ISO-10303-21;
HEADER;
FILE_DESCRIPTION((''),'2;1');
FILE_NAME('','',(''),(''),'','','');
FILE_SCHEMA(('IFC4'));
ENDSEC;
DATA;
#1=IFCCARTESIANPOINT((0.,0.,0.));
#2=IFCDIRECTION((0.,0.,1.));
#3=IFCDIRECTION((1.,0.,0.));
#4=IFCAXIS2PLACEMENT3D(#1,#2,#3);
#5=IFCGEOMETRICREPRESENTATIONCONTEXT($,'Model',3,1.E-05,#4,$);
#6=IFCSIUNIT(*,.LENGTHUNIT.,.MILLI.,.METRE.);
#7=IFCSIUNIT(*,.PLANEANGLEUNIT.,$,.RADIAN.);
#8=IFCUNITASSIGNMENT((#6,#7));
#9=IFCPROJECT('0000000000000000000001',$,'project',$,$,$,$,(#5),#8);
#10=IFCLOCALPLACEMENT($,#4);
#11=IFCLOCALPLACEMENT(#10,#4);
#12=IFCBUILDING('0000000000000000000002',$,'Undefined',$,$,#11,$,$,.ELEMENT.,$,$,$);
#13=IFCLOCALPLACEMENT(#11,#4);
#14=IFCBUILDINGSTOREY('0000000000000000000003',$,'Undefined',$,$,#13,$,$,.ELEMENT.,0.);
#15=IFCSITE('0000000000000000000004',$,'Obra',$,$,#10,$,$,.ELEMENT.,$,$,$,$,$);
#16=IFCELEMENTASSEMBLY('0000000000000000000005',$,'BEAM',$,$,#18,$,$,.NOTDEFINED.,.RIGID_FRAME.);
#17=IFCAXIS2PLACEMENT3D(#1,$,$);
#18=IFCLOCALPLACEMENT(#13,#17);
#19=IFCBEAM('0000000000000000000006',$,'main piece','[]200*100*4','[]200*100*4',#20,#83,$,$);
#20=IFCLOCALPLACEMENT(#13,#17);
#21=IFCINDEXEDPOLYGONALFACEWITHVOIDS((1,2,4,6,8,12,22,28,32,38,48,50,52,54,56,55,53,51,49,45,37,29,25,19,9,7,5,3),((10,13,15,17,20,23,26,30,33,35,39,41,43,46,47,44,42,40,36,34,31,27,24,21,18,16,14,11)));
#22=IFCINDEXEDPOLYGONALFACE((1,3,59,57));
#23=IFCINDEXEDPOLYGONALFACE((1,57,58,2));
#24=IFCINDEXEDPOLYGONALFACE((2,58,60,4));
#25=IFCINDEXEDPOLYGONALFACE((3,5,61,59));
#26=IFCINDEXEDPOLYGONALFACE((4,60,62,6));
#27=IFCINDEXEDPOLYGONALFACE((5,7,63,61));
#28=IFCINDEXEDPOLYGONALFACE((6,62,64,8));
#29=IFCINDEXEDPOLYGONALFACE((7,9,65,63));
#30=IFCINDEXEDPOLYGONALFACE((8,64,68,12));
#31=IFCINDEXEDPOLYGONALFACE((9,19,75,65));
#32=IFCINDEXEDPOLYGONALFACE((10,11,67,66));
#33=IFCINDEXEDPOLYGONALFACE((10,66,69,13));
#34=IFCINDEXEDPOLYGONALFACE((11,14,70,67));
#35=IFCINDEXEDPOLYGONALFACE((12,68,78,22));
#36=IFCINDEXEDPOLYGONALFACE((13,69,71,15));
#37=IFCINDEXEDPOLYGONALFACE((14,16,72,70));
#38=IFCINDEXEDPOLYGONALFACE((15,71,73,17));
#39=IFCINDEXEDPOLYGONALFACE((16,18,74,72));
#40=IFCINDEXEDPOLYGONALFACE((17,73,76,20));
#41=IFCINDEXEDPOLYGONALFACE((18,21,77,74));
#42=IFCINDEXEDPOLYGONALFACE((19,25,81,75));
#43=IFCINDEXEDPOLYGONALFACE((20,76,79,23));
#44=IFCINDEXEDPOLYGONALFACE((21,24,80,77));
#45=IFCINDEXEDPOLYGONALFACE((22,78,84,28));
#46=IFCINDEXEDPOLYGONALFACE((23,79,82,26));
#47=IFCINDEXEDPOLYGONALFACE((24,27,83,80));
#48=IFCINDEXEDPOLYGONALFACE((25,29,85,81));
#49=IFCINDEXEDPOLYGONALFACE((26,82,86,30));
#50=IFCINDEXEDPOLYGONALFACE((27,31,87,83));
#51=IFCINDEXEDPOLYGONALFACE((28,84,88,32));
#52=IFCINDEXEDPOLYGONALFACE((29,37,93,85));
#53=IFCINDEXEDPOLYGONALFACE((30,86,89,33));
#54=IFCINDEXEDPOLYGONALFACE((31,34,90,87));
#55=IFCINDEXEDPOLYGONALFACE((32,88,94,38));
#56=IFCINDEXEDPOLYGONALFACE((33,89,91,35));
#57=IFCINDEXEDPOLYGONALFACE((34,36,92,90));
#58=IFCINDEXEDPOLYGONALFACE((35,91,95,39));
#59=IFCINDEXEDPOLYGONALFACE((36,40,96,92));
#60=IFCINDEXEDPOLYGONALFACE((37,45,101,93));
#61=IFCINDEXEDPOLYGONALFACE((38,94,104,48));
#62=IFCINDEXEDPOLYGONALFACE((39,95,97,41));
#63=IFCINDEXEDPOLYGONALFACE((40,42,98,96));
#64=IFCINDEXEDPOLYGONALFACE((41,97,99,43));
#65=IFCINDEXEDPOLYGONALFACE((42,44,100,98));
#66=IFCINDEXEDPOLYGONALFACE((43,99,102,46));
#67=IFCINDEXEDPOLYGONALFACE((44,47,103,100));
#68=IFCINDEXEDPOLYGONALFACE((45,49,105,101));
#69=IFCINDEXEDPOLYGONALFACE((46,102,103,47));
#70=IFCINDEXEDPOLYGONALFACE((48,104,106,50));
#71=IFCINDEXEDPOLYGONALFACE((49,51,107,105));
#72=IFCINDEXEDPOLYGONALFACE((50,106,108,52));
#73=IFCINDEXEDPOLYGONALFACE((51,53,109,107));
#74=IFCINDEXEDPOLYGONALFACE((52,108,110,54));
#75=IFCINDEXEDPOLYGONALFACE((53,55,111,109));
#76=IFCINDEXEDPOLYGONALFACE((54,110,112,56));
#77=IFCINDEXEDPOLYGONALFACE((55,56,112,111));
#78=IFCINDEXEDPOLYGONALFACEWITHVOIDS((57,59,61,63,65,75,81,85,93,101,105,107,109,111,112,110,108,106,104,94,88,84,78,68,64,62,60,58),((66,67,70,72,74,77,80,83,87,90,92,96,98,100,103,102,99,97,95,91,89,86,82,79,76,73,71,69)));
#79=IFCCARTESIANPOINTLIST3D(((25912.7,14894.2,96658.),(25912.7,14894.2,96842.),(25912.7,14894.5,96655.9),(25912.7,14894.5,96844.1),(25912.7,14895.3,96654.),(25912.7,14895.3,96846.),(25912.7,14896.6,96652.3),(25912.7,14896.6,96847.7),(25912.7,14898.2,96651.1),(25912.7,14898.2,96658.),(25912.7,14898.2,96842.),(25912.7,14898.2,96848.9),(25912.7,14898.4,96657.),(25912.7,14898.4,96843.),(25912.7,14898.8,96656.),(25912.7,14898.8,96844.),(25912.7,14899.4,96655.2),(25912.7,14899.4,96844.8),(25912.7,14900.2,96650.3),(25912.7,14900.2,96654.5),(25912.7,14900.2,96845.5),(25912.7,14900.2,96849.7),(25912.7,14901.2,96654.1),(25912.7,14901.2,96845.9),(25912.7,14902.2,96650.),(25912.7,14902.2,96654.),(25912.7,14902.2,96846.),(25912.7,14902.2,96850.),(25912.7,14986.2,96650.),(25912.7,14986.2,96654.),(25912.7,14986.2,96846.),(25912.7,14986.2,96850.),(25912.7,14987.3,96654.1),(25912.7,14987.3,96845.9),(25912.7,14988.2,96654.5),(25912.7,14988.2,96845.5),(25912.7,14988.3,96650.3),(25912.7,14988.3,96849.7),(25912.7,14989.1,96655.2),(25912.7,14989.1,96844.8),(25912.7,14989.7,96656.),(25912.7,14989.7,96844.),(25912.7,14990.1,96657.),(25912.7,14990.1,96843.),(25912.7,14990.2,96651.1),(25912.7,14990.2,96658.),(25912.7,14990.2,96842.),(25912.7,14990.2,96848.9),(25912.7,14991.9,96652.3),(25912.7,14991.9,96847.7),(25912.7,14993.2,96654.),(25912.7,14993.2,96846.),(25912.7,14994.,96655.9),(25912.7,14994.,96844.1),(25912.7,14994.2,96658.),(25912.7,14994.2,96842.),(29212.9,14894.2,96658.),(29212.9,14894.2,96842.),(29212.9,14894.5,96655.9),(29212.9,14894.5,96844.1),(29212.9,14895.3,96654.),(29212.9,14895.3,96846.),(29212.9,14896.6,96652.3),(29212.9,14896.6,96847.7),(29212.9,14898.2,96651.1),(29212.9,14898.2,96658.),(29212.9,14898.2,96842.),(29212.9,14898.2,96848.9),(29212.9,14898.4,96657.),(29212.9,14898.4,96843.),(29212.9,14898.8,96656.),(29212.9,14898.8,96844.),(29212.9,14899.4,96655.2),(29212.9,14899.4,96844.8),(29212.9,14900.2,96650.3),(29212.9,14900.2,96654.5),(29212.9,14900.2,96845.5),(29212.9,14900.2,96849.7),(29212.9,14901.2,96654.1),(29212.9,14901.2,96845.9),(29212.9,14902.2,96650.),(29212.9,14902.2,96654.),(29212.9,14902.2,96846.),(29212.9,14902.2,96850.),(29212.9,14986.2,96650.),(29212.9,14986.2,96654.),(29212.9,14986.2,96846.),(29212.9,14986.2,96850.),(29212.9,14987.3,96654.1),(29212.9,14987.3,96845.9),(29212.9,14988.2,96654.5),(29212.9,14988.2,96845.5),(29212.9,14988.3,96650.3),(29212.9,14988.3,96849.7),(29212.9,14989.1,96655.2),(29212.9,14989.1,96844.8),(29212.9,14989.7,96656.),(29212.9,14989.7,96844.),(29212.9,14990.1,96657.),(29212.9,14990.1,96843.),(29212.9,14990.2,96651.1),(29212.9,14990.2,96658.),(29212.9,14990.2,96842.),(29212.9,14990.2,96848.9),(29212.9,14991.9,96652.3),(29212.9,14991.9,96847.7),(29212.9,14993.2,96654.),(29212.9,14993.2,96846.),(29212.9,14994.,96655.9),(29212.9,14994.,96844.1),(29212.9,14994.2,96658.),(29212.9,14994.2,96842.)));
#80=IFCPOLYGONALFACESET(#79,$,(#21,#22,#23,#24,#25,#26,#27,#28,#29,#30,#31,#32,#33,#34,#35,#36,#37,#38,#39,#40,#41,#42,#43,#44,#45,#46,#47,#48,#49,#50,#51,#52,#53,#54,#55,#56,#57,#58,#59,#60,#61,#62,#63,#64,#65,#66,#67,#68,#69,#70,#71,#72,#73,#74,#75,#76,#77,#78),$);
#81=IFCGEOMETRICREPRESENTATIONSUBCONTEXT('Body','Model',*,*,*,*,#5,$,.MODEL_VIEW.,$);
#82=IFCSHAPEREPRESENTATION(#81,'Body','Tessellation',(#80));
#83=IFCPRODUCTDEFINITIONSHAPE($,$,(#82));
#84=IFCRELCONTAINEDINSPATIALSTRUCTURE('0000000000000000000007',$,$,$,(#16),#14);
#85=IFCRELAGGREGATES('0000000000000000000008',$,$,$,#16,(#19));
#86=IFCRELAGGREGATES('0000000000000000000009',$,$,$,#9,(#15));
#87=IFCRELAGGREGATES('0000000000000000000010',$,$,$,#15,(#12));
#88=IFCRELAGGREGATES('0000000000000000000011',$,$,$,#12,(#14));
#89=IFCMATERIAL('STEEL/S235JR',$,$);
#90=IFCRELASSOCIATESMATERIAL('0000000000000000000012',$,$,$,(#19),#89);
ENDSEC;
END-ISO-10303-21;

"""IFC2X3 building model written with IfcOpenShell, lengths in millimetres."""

from ifc_helpers import new_model, si_unit, frame, origin_with_axes, origin_2d_with_axis, place, context, subcontext, project, spatial, hollow_rectangle, extrude, material, element, aggregate, save


model = new_model("IFC2X3")

# Units and contexts
model_context = context("Model", 3, precision=1e-05, world=origin_with_axes())
body_context = subcontext(model_context, "Body", "Model", "MODEL_VIEW")
ifc_project = project(units=[si_unit("LENGTHUNIT", "METRE", prefix="MILLI"), si_unit("PLANEANGLEUNIT", "RADIAN")], contexts=[model_context])

# Site, building, storey
site_placement = place(None, origin_with_axes())
site = spatial("IfcSite", under=ifc_project, at=site_placement, Name="Obra", CompositionType="ELEMENT")
building_placement = place(site_placement, origin_with_axes())
building = spatial("IfcBuilding", under=site, at=building_placement, Name="Undefined", CompositionType="ELEMENT")
storey_placement = place(building_placement, origin_with_axes())
storey = spatial("IfcBuildingStorey", under=building, at=storey_placement, Name="Undefined", CompositionType="ELEMENT", Elevation=0.0)

# Shared definitions
ifc_material = material(Name="STEEL/S235JR")

# Element assembly, beam
assembly_1_placement = place(storey_placement, origin_with_axes())
assembly_1 = element("IfcElementAssembly", 1, at=assembly_1_placement, inside=storey, Name="BEAM", AssemblyPlace="NOTDEFINED", PredefinedType="RIGID_FRAME")
beam_1_placement = place(assembly_1_placement, frame((25912.7, 14944.2, 96750.0), z_axis=(0.0, 0.0, 1.0), x_axis=(1.0, 0.0, 0.0)))
beam_1 = element("IfcBeam", 2, at=beam_1_placement, material=ifc_material, Name="main piece", Description="[]200*100*4", ObjectType="[]200*100*4", context=body_context, shape_type="SweptSolid", body=[
    extrude(hollow_rectangle(XDim=100.0, YDim=200.0, WallThickness=4.0, InnerFilletRadius=4.0, OuterFilletRadius=8.0, at=origin_2d_with_axis()), frame((3300.2, 0.0, 0.0), z_axis=(-1.0, 0.0, 0.0), x_axis=(0.0, -1.0, 0.0)), (0.0, 0.0, 1.0), 3300.2),
])
aggregate(assembly_1, [beam_1])

save(model, "model.ifc")
